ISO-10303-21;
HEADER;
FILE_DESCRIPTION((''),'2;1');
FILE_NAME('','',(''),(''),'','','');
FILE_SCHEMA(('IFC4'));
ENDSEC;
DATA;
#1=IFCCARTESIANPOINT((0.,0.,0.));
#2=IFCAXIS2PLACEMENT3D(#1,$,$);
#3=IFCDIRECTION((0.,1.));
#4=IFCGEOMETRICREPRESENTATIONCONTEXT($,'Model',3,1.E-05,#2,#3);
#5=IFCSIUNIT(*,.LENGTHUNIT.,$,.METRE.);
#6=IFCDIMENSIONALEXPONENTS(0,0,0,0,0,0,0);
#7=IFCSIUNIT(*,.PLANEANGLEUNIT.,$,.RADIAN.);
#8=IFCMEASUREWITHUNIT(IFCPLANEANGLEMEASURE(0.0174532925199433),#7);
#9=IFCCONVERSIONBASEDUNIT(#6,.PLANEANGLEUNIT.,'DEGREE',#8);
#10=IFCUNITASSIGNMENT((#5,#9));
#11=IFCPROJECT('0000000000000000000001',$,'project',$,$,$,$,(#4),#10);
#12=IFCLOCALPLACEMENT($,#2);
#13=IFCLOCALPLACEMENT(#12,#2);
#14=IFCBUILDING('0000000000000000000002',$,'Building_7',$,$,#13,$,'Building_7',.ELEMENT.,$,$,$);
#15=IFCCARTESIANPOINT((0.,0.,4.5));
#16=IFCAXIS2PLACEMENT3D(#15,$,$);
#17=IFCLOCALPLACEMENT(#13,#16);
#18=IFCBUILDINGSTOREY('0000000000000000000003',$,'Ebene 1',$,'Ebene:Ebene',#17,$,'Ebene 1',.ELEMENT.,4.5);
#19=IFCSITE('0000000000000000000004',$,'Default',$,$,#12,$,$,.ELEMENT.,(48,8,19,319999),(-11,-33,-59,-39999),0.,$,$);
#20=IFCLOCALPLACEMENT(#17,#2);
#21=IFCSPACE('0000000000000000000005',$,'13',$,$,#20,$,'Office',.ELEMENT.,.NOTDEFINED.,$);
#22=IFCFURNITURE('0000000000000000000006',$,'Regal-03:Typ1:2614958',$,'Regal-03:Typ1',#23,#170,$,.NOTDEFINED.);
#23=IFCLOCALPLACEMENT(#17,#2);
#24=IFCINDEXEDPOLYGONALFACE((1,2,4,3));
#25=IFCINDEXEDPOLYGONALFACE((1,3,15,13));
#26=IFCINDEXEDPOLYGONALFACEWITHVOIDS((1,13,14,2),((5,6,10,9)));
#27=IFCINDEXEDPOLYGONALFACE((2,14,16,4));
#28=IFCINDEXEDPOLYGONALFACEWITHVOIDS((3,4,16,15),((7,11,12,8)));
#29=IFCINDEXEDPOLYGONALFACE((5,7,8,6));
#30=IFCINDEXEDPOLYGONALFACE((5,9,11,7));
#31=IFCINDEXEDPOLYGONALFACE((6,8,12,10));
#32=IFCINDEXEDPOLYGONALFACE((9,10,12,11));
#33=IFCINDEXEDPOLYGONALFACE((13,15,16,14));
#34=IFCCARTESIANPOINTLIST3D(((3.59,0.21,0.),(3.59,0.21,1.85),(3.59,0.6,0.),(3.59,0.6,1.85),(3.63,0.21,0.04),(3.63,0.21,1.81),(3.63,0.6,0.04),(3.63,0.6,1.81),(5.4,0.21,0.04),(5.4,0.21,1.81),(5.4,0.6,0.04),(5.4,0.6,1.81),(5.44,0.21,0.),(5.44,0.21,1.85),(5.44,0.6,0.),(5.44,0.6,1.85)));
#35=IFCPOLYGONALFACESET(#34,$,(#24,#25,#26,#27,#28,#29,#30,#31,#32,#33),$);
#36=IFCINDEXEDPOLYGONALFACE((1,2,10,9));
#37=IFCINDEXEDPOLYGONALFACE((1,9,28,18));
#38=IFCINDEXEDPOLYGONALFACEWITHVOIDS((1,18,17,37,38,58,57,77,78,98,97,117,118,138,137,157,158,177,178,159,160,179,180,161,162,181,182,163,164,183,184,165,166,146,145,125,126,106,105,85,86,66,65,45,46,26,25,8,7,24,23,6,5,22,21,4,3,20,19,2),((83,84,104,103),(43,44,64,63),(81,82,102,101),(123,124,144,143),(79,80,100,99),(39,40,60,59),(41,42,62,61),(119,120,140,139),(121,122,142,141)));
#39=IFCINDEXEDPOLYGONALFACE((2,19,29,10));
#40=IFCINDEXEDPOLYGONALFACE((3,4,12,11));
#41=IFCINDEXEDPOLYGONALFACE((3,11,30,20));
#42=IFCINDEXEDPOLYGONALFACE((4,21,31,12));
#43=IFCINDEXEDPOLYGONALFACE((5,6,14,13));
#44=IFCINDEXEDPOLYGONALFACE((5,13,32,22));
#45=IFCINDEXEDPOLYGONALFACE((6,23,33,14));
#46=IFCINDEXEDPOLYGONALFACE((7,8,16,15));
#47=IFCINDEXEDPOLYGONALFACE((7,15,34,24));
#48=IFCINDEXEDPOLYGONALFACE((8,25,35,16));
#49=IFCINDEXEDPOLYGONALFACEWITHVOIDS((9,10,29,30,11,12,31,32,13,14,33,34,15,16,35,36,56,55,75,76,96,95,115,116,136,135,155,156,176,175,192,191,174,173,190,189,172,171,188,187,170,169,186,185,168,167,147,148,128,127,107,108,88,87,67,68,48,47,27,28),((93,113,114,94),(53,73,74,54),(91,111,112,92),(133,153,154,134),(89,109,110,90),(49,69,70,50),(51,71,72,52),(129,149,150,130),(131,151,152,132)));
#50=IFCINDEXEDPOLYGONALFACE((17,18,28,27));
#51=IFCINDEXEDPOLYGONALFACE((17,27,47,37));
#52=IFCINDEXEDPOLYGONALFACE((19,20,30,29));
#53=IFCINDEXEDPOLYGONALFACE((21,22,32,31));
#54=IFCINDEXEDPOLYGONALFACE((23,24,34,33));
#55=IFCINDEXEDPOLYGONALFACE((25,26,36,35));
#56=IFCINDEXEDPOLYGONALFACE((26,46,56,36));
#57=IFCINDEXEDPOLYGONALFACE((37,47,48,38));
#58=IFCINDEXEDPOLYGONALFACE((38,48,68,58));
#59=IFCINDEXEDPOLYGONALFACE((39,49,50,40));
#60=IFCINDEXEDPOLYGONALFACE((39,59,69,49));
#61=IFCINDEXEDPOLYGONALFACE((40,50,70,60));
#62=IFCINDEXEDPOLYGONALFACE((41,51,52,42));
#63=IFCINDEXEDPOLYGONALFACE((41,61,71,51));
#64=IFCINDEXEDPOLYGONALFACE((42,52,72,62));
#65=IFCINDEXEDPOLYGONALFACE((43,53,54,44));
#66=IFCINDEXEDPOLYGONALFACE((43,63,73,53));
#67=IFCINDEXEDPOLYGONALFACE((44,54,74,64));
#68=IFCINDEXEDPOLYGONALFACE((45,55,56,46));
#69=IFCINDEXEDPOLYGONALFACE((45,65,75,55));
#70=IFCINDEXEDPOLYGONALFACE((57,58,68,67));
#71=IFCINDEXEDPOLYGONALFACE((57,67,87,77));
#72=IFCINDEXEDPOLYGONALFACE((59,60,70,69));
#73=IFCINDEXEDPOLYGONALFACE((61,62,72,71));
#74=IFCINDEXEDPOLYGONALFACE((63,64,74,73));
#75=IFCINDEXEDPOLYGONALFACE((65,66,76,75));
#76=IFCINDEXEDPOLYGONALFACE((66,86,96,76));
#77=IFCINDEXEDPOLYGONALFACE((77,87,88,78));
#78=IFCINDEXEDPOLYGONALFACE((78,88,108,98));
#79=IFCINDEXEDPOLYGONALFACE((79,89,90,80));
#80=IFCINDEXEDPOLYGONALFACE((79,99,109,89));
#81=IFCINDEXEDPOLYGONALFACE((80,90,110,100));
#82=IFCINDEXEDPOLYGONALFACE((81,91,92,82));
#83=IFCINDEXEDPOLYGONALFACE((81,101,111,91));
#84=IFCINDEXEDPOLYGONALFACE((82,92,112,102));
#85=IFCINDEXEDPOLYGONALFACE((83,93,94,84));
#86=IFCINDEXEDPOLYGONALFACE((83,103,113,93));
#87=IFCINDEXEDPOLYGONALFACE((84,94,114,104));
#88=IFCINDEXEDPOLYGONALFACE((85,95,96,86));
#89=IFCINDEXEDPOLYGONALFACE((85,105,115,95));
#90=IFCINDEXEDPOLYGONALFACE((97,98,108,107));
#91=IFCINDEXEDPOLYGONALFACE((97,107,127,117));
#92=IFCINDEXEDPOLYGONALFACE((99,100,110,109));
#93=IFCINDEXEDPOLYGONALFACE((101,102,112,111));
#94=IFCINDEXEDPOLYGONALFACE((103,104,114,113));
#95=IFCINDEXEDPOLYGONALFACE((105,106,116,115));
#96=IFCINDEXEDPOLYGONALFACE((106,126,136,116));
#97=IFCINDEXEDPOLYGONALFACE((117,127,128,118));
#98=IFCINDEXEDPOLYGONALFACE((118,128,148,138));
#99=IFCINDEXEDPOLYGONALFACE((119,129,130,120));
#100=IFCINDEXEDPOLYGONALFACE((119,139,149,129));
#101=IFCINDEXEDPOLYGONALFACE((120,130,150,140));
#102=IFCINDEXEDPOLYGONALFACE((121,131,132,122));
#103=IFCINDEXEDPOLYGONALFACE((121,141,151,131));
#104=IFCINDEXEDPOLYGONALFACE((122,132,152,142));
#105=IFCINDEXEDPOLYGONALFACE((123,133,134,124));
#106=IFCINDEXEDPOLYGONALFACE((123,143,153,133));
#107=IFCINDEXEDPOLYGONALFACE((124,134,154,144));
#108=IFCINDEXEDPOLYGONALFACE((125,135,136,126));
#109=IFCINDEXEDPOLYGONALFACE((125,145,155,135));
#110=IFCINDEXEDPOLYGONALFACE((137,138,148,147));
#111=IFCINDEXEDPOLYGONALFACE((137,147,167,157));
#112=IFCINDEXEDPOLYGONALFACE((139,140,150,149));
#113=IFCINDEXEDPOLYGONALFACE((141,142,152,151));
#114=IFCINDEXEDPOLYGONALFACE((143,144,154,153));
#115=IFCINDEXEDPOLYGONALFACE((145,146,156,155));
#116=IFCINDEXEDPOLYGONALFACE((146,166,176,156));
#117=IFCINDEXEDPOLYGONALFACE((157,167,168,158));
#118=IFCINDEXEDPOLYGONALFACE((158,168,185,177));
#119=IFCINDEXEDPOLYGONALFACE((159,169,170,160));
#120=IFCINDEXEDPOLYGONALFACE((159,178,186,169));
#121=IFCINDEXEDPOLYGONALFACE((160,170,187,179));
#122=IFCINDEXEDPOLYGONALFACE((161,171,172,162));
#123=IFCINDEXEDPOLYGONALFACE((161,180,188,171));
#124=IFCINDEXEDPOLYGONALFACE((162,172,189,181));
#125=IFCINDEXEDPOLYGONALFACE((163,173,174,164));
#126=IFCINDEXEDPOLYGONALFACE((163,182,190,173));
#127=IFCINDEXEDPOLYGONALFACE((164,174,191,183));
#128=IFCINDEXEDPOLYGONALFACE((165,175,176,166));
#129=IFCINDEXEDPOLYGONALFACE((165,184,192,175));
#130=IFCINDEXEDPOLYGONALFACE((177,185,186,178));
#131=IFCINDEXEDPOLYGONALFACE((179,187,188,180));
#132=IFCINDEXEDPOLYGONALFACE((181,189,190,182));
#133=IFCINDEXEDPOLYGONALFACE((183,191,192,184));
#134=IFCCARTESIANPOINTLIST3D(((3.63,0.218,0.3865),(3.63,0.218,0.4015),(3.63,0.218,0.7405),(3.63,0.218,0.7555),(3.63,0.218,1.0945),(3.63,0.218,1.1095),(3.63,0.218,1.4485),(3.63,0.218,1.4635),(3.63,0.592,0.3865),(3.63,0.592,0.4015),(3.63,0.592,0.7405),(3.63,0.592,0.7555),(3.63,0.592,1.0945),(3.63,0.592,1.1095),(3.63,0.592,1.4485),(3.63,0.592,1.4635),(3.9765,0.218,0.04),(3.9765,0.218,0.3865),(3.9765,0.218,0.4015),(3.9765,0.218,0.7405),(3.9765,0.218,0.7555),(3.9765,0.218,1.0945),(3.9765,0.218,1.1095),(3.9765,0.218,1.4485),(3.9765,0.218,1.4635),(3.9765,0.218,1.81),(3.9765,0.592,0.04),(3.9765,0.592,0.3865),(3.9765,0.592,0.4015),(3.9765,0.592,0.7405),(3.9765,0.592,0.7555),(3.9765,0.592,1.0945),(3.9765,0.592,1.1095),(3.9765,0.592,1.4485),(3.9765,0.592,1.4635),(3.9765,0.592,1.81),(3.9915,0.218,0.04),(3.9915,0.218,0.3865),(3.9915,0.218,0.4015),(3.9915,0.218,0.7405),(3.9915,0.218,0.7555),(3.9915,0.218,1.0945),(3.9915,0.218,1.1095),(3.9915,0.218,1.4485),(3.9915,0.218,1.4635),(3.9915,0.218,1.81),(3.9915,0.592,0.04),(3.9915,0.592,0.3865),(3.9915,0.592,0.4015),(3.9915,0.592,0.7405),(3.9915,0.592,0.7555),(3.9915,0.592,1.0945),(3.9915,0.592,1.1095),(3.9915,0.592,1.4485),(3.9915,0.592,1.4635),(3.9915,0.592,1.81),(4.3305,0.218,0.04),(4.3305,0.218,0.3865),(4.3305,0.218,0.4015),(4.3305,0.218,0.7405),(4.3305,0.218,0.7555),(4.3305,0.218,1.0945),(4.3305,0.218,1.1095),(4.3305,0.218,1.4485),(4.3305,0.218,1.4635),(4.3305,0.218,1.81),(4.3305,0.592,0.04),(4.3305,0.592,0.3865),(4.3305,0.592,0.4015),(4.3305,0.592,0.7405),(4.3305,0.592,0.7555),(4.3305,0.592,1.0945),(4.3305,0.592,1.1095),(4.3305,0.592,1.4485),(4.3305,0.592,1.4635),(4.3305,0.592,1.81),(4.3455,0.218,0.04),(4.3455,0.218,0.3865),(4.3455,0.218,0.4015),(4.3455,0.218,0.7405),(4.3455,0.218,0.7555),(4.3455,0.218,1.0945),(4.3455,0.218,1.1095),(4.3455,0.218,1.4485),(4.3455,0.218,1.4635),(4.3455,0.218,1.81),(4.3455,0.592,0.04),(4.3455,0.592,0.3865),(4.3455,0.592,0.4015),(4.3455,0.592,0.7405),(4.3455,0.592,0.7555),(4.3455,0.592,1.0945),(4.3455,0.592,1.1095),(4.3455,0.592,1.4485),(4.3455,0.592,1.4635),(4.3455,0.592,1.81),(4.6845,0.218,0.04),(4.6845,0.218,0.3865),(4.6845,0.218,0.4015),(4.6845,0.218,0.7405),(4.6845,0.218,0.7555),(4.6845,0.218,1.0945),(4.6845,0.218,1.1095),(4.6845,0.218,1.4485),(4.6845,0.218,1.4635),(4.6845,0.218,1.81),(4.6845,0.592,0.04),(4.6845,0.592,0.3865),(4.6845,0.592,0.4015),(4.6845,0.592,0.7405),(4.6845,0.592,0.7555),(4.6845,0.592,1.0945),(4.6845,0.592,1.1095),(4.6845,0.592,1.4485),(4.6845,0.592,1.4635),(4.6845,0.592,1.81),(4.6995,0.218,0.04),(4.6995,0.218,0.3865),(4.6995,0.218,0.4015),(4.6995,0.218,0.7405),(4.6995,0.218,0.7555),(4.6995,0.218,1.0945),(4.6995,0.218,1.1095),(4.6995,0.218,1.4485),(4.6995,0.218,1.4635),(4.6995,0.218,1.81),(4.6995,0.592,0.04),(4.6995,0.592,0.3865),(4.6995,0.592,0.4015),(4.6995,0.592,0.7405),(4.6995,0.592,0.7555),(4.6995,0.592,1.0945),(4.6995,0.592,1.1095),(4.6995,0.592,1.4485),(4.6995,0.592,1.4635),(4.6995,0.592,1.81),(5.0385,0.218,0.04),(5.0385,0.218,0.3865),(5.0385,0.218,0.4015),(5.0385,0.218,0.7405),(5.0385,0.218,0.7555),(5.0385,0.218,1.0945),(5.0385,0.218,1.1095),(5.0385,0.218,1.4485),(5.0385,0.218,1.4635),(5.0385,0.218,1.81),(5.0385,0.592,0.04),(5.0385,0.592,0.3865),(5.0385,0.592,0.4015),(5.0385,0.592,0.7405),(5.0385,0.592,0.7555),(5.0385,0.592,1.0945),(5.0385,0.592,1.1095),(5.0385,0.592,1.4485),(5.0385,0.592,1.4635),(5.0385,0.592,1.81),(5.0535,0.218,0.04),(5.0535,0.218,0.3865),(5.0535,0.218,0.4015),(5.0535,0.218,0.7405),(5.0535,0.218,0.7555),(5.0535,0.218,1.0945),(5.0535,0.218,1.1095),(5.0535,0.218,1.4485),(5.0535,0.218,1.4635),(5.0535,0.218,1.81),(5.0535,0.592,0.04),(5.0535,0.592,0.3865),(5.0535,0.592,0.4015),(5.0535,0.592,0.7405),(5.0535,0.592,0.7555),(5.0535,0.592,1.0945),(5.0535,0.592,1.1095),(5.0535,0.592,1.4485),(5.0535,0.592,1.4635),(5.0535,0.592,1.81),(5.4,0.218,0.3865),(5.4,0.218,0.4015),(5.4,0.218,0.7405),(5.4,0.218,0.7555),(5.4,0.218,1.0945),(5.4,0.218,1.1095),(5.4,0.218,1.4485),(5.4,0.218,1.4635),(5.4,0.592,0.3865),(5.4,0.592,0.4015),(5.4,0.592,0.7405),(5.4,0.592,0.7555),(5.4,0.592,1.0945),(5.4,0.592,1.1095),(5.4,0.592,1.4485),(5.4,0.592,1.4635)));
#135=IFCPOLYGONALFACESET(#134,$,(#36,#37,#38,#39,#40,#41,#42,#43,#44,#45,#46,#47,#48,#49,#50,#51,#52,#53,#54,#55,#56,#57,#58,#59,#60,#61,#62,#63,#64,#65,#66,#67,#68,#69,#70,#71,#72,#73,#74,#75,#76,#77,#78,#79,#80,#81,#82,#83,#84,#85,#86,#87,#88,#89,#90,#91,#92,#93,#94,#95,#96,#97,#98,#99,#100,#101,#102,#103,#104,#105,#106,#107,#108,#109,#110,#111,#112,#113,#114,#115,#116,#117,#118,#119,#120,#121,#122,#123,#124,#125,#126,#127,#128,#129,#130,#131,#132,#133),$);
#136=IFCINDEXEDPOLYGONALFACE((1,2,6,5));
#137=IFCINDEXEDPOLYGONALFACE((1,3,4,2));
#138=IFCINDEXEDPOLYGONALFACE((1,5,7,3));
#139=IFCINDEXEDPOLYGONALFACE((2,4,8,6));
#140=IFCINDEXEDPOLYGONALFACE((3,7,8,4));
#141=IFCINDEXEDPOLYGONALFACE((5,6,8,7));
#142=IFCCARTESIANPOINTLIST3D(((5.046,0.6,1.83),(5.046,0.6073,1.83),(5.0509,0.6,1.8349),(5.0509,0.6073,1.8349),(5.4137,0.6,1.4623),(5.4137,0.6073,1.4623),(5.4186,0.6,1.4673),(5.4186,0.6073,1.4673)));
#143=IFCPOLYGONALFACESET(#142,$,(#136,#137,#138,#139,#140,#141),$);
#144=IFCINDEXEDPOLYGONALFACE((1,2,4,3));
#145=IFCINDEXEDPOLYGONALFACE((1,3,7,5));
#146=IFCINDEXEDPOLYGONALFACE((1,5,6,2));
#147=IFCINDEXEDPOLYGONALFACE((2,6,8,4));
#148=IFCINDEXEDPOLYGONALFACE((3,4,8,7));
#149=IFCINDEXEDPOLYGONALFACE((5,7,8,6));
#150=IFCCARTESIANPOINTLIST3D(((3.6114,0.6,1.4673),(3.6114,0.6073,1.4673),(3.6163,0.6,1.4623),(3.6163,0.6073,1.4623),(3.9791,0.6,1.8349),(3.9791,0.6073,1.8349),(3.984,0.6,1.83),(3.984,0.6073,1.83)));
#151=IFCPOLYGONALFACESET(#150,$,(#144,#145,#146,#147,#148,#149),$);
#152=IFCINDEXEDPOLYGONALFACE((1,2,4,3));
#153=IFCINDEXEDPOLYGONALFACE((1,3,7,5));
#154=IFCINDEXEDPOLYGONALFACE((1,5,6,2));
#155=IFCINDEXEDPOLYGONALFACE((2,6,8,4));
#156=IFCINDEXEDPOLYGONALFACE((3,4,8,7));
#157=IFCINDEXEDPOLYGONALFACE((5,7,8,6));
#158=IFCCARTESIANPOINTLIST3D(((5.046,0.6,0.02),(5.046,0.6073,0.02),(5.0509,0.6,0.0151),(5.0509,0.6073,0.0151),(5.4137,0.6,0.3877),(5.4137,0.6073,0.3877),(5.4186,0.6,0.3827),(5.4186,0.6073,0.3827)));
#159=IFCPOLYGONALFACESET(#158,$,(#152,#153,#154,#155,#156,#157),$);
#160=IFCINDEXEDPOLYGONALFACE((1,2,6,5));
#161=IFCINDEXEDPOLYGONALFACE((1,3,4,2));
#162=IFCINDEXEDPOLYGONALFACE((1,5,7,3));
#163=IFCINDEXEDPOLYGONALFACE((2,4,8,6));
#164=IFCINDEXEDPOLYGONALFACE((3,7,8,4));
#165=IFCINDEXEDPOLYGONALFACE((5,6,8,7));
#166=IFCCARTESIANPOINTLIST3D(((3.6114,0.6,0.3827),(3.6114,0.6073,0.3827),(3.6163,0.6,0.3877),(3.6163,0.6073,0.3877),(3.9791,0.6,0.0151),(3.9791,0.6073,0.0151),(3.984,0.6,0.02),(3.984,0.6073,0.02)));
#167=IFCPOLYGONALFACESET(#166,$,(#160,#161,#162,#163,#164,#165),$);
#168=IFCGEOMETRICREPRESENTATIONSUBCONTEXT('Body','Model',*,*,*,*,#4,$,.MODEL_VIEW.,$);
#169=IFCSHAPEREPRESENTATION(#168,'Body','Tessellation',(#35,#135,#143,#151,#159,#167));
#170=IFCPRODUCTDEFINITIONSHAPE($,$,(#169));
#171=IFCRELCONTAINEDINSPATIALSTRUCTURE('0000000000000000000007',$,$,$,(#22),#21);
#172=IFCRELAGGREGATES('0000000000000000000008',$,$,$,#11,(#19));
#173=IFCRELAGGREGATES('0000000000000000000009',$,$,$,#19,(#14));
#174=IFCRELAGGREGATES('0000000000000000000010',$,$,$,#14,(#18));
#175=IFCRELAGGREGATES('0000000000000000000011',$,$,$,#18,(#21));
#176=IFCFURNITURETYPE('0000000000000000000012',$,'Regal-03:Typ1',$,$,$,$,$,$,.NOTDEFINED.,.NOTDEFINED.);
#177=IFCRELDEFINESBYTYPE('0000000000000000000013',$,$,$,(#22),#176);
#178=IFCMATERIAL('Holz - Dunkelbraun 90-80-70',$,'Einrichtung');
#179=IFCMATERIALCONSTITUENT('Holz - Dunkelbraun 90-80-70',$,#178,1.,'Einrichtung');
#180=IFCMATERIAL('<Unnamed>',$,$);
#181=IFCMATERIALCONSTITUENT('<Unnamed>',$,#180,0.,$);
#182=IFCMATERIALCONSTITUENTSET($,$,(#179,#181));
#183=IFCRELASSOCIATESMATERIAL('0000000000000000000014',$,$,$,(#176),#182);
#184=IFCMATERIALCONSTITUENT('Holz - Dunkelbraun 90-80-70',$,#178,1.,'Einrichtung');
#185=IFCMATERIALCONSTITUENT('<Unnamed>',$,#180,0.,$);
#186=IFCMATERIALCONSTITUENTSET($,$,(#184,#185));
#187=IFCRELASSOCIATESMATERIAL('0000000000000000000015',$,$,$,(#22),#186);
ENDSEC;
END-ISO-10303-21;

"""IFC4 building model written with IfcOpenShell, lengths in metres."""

from ifc_helpers import new_model, entity, si_unit, converted_unit, direction, frame, origin, place, context, subcontext, project, spatial, indexed_curve, outline, extrude, source, transform, mapped, material, constituent, constituent_set, type_object, type_shapes, element, save


model = new_model("IFC4")

# Units and contexts
model_context = context("Model", 3, precision=1e-05, world=origin(), true_north=direction((0.0, 1.0)))
body_context = subcontext(model_context, "Body", "Model", "MODEL_VIEW")
ifc_project = project(units=[si_unit("LENGTHUNIT", "METRE"), converted_unit("PLANEANGLEUNIT", "DEGREE", entity("IfcPlaneAngleMeasure", 0.0174532925199433), si_unit("PLANEANGLEUNIT", "RADIAN"), dimensions=[0, 0, 0, 0, 0, 0, 0])], contexts=[model_context])

# Site, building, storey
site_placement = place(None, origin())
site = spatial("IfcSite", under=ifc_project, at=site_placement, Name="Default", CompositionType="ELEMENT", RefLatitude=(48, 8, 19, 319999), RefLongitude=(-11, -33, -59, -39999), RefElevation=0.0)
building_placement = place(site_placement, origin())
building = spatial("IfcBuilding", under=site, at=building_placement, Name="Building_7", LongName="Building_7", CompositionType="ELEMENT")
storey_placement = place(building_placement, frame((0.0, 0.0, 4.5)))
storey = spatial("IfcBuildingStorey", under=building, at=storey_placement, Name="Ebene 1", ObjectType="Ebene:Ebene", LongName="Ebene 1", CompositionType="ELEMENT", Elevation=4.5)

# Shared definitions
ifc_material_1 = material(Name="<Unnamed>")

# Shared definitions
space_1_placement = place(storey_placement, origin())
space_1 = spatial("IfcSpace", under=storey, at=space_1_placement, Name="13", LongName="Office", CompositionType="ELEMENT", PredefinedType="NOTDEFINED")

# Furniture
ifc_material_2 = material(Name="Holz - Dunkelbraun 90-80-70", Category="Einrichtung")
ifc_constituent_1 = constituent(ifc_material_2, Name="Holz - Dunkelbraun 90-80-70", Category="Einrichtung", fraction=1.0)
ifc_constituent_2 = constituent(ifc_material_1, Name="<Unnamed>", fraction=0.0)
ifc_constituent_set_1 = constituent_set(constituents=[ifc_constituent_1, ifc_constituent_2])
ifc_constituent_3 = constituent(ifc_material_2, Name="Holz - Dunkelbraun 90-80-70", Category="Einrichtung", fraction=1.0)
ifc_constituent_4 = constituent(ifc_material_1, Name="<Unnamed>", fraction=0.0)
ifc_constituent_set_2 = constituent_set(constituents=[ifc_constituent_3, ifc_constituent_4])
furniture_type_1 = type_object("IfcFurnitureType", Name="Regal-03:Typ1", AssemblyPlace="NOTDEFINED", PredefinedType="NOTDEFINED", material=ifc_constituent_set_2)
shared_shape_1 = source(origin(), body_context, "Body", "SweptSolid", [
    extrude(outline(indexed_curve([(-0.925, -0.925), (0.925, -0.925), (0.925, 0.925), (-0.925, 0.925), (-0.925, -0.925)], self_intersect=False), holes=[indexed_curve([(-0.885, -0.885), (-0.885, 0.885), (0.885, 0.885), (0.885, -0.885), (-0.885, -0.885)], self_intersect=False)]), frame((0.2471, -0.2651, 0.925), z_axis=(0.0, 1.0, 0.0), x_axis=(0.0, 0.0, -1.0)), (0.0, 0.0, 1.0), 0.39),
    extrude(outline(indexed_curve([(0.5385, -0.5385), (0.885, -0.5385), (0.885, -0.5235), (0.5385, -0.5235), (0.5385, -0.1845), (0.885, -0.1845), (0.885, -0.1695), (0.5385, -0.1695), (0.5385, 0.1695), (0.885, 0.1695), (0.885, 0.1845), (0.5385, 0.1845), (0.5385, 0.5235), (0.885, 0.5235), (0.885, 0.5385), (0.5385, 0.5385), (0.5385, 0.885), (0.5235, 0.885), (0.5235, 0.5385), (0.1845, 0.5385), (0.1845, 0.885), (0.1695, 0.885), (0.1695, 0.5385), (-0.1695, 0.5385), (-0.1695, 0.885), (-0.1845, 0.885), (-0.1845, 0.5385), (-0.5235, 0.5385), (-0.5235, 0.885), (-0.5385, 0.885), (-0.5385, 0.5385), (-0.885, 0.5385), (-0.885, 0.5235), (-0.5385, 0.5235), (-0.5385, 0.1845), (-0.885, 0.1845), (-0.885, 0.1695), (-0.5385, 0.1695), (-0.5385, -0.1695), (-0.885, -0.1695), (-0.885, -0.1845), (-0.5385, -0.1845), (-0.5385, -0.5235), (-0.885, -0.5235), (-0.885, -0.5385), (-0.5385, -0.5385), (-0.5385, -0.885), (-0.5235, -0.885), (-0.5235, -0.5385), (-0.1845, -0.5385), (-0.1845, -0.885), (-0.1695, -0.885), (-0.1695, -0.5385), (0.1695, -0.5385), (0.1695, -0.885), (0.1845, -0.885), (0.1845, -0.5385), (0.5235, -0.5385), (0.5235, -0.885), (0.5385, -0.885), (0.5385, -0.5385)], self_intersect=False), holes=[indexed_curve([(0.5235, -0.1845), (0.5235, -0.5235), (0.1845, -0.5235), (0.1845, -0.1845), (0.5235, -0.1845)], self_intersect=False), indexed_curve([(0.1845, -0.1695), (0.1845, 0.1695), (0.5235, 0.1695), (0.5235, -0.1695), (0.1845, -0.1695)], self_intersect=False), indexed_curve([(0.1845, 0.1845), (0.1845, 0.5235), (0.5235, 0.5235), (0.5235, 0.1845), (0.1845, 0.1845)], self_intersect=False), indexed_curve([(-0.1695, 0.5235), (0.1695, 0.5235), (0.1695, 0.1845), (-0.1695, 0.1845), (-0.1695, 0.5235)], self_intersect=False), indexed_curve([(-0.1695, 0.1695), (0.1695, 0.1695), (0.1695, -0.1695), (-0.1695, -0.1695), (-0.1695, 0.1695)], self_intersect=False), indexed_curve([(-0.1695, -0.1845), (0.1695, -0.1845), (0.1695, -0.5235), (-0.1695, -0.5235), (-0.1695, -0.1845)], self_intersect=False), indexed_curve([(-0.5235, -0.5235), (-0.5235, -0.1845), (-0.1845, -0.1845), (-0.1845, -0.5235), (-0.5235, -0.5235)], self_intersect=False), indexed_curve([(-0.5235, -0.1695), (-0.5235, 0.1695), (-0.1845, 0.1695), (-0.1845, -0.1695), (-0.5235, -0.1695)], self_intersect=False), indexed_curve([(-0.5235, 0.1845), (-0.5235, 0.5235), (-0.1845, 0.5235), (-0.1845, 0.1845), (-0.5235, 0.1845)], self_intersect=False)]), frame((0.2471, -0.2571, 0.925), z_axis=(0.0, 1.0, 0.0), x_axis=(0.0, 0.0, 1.0)), (0.0, 0.0, 1.0), 0.374),
    extrude(outline(indexed_curve([(-0.0037, -0.0035), (0.0037, -0.0035), (0.0037, 0.0035), (-0.0037, 0.0035), (-0.0037, -0.0035)], self_intersect=False)), frame((1.1482, 0.1286, 1.4648), z_axis=(-0.707107, 0.0, 0.707107), x_axis=(0.0, 1.0, 0.0)), (0.0, 0.0, 1.0), 0.52),
    extrude(outline(indexed_curve([(-0.0037, -0.0035), (0.0037, -0.0035), (0.0037, 0.0035), (-0.0037, 0.0035), (-0.0037, -0.0035)], self_intersect=False)), frame((-0.6541, 0.1286, 1.4648), z_axis=(0.707107, 0.0, 0.707107), x_axis=(0.0, 1.0, 0.0)), (0.0, 0.0, 1.0), 0.52),
    extrude(outline(indexed_curve([(-0.0037, -0.0035), (0.0037, -0.0035), (0.0037, 0.0035), (-0.0037, 0.0035), (-0.0037, -0.0035)], self_intersect=False)), frame((0.7805, 0.1286, 0.0175), z_axis=(0.707107, 0.0, 0.707107), x_axis=(0.0, 1.0, 0.0)), (0.0, 0.0, 1.0), 0.52),
    extrude(outline(indexed_curve([(-0.0037, -0.0035), (0.0037, -0.0035), (0.0037, 0.0035), (-0.0037, 0.0035), (-0.0037, -0.0035)], self_intersect=False)), frame((-0.2864, 0.1286, 0.0175), z_axis=(-0.707107, 0.0, 0.707107), x_axis=(0.0, 1.0, 0.0)), (0.0, 0.0, 1.0), 0.52),
])
type_shapes(furniture_type_1, [shared_shape_1])
furniture_1_placement = place(space_1_placement, frame((4.2679, 0.4751, 0.0)))
element("IfcFurniture", 1, at=furniture_1_placement, inside=space_1, type_object=furniture_type_1, material=ifc_constituent_set_1, Name="Regal-03:Typ1:2614958", ObjectType="Regal-03:Typ1", PredefinedType="NOTDEFINED", context=body_context, shape_type="MappedRepresentation", body=[
    mapped(shared_shape_1, transform((0.0, 0.0, 0.0), scale=1.0)),
])

save(model, "model.ifc")
